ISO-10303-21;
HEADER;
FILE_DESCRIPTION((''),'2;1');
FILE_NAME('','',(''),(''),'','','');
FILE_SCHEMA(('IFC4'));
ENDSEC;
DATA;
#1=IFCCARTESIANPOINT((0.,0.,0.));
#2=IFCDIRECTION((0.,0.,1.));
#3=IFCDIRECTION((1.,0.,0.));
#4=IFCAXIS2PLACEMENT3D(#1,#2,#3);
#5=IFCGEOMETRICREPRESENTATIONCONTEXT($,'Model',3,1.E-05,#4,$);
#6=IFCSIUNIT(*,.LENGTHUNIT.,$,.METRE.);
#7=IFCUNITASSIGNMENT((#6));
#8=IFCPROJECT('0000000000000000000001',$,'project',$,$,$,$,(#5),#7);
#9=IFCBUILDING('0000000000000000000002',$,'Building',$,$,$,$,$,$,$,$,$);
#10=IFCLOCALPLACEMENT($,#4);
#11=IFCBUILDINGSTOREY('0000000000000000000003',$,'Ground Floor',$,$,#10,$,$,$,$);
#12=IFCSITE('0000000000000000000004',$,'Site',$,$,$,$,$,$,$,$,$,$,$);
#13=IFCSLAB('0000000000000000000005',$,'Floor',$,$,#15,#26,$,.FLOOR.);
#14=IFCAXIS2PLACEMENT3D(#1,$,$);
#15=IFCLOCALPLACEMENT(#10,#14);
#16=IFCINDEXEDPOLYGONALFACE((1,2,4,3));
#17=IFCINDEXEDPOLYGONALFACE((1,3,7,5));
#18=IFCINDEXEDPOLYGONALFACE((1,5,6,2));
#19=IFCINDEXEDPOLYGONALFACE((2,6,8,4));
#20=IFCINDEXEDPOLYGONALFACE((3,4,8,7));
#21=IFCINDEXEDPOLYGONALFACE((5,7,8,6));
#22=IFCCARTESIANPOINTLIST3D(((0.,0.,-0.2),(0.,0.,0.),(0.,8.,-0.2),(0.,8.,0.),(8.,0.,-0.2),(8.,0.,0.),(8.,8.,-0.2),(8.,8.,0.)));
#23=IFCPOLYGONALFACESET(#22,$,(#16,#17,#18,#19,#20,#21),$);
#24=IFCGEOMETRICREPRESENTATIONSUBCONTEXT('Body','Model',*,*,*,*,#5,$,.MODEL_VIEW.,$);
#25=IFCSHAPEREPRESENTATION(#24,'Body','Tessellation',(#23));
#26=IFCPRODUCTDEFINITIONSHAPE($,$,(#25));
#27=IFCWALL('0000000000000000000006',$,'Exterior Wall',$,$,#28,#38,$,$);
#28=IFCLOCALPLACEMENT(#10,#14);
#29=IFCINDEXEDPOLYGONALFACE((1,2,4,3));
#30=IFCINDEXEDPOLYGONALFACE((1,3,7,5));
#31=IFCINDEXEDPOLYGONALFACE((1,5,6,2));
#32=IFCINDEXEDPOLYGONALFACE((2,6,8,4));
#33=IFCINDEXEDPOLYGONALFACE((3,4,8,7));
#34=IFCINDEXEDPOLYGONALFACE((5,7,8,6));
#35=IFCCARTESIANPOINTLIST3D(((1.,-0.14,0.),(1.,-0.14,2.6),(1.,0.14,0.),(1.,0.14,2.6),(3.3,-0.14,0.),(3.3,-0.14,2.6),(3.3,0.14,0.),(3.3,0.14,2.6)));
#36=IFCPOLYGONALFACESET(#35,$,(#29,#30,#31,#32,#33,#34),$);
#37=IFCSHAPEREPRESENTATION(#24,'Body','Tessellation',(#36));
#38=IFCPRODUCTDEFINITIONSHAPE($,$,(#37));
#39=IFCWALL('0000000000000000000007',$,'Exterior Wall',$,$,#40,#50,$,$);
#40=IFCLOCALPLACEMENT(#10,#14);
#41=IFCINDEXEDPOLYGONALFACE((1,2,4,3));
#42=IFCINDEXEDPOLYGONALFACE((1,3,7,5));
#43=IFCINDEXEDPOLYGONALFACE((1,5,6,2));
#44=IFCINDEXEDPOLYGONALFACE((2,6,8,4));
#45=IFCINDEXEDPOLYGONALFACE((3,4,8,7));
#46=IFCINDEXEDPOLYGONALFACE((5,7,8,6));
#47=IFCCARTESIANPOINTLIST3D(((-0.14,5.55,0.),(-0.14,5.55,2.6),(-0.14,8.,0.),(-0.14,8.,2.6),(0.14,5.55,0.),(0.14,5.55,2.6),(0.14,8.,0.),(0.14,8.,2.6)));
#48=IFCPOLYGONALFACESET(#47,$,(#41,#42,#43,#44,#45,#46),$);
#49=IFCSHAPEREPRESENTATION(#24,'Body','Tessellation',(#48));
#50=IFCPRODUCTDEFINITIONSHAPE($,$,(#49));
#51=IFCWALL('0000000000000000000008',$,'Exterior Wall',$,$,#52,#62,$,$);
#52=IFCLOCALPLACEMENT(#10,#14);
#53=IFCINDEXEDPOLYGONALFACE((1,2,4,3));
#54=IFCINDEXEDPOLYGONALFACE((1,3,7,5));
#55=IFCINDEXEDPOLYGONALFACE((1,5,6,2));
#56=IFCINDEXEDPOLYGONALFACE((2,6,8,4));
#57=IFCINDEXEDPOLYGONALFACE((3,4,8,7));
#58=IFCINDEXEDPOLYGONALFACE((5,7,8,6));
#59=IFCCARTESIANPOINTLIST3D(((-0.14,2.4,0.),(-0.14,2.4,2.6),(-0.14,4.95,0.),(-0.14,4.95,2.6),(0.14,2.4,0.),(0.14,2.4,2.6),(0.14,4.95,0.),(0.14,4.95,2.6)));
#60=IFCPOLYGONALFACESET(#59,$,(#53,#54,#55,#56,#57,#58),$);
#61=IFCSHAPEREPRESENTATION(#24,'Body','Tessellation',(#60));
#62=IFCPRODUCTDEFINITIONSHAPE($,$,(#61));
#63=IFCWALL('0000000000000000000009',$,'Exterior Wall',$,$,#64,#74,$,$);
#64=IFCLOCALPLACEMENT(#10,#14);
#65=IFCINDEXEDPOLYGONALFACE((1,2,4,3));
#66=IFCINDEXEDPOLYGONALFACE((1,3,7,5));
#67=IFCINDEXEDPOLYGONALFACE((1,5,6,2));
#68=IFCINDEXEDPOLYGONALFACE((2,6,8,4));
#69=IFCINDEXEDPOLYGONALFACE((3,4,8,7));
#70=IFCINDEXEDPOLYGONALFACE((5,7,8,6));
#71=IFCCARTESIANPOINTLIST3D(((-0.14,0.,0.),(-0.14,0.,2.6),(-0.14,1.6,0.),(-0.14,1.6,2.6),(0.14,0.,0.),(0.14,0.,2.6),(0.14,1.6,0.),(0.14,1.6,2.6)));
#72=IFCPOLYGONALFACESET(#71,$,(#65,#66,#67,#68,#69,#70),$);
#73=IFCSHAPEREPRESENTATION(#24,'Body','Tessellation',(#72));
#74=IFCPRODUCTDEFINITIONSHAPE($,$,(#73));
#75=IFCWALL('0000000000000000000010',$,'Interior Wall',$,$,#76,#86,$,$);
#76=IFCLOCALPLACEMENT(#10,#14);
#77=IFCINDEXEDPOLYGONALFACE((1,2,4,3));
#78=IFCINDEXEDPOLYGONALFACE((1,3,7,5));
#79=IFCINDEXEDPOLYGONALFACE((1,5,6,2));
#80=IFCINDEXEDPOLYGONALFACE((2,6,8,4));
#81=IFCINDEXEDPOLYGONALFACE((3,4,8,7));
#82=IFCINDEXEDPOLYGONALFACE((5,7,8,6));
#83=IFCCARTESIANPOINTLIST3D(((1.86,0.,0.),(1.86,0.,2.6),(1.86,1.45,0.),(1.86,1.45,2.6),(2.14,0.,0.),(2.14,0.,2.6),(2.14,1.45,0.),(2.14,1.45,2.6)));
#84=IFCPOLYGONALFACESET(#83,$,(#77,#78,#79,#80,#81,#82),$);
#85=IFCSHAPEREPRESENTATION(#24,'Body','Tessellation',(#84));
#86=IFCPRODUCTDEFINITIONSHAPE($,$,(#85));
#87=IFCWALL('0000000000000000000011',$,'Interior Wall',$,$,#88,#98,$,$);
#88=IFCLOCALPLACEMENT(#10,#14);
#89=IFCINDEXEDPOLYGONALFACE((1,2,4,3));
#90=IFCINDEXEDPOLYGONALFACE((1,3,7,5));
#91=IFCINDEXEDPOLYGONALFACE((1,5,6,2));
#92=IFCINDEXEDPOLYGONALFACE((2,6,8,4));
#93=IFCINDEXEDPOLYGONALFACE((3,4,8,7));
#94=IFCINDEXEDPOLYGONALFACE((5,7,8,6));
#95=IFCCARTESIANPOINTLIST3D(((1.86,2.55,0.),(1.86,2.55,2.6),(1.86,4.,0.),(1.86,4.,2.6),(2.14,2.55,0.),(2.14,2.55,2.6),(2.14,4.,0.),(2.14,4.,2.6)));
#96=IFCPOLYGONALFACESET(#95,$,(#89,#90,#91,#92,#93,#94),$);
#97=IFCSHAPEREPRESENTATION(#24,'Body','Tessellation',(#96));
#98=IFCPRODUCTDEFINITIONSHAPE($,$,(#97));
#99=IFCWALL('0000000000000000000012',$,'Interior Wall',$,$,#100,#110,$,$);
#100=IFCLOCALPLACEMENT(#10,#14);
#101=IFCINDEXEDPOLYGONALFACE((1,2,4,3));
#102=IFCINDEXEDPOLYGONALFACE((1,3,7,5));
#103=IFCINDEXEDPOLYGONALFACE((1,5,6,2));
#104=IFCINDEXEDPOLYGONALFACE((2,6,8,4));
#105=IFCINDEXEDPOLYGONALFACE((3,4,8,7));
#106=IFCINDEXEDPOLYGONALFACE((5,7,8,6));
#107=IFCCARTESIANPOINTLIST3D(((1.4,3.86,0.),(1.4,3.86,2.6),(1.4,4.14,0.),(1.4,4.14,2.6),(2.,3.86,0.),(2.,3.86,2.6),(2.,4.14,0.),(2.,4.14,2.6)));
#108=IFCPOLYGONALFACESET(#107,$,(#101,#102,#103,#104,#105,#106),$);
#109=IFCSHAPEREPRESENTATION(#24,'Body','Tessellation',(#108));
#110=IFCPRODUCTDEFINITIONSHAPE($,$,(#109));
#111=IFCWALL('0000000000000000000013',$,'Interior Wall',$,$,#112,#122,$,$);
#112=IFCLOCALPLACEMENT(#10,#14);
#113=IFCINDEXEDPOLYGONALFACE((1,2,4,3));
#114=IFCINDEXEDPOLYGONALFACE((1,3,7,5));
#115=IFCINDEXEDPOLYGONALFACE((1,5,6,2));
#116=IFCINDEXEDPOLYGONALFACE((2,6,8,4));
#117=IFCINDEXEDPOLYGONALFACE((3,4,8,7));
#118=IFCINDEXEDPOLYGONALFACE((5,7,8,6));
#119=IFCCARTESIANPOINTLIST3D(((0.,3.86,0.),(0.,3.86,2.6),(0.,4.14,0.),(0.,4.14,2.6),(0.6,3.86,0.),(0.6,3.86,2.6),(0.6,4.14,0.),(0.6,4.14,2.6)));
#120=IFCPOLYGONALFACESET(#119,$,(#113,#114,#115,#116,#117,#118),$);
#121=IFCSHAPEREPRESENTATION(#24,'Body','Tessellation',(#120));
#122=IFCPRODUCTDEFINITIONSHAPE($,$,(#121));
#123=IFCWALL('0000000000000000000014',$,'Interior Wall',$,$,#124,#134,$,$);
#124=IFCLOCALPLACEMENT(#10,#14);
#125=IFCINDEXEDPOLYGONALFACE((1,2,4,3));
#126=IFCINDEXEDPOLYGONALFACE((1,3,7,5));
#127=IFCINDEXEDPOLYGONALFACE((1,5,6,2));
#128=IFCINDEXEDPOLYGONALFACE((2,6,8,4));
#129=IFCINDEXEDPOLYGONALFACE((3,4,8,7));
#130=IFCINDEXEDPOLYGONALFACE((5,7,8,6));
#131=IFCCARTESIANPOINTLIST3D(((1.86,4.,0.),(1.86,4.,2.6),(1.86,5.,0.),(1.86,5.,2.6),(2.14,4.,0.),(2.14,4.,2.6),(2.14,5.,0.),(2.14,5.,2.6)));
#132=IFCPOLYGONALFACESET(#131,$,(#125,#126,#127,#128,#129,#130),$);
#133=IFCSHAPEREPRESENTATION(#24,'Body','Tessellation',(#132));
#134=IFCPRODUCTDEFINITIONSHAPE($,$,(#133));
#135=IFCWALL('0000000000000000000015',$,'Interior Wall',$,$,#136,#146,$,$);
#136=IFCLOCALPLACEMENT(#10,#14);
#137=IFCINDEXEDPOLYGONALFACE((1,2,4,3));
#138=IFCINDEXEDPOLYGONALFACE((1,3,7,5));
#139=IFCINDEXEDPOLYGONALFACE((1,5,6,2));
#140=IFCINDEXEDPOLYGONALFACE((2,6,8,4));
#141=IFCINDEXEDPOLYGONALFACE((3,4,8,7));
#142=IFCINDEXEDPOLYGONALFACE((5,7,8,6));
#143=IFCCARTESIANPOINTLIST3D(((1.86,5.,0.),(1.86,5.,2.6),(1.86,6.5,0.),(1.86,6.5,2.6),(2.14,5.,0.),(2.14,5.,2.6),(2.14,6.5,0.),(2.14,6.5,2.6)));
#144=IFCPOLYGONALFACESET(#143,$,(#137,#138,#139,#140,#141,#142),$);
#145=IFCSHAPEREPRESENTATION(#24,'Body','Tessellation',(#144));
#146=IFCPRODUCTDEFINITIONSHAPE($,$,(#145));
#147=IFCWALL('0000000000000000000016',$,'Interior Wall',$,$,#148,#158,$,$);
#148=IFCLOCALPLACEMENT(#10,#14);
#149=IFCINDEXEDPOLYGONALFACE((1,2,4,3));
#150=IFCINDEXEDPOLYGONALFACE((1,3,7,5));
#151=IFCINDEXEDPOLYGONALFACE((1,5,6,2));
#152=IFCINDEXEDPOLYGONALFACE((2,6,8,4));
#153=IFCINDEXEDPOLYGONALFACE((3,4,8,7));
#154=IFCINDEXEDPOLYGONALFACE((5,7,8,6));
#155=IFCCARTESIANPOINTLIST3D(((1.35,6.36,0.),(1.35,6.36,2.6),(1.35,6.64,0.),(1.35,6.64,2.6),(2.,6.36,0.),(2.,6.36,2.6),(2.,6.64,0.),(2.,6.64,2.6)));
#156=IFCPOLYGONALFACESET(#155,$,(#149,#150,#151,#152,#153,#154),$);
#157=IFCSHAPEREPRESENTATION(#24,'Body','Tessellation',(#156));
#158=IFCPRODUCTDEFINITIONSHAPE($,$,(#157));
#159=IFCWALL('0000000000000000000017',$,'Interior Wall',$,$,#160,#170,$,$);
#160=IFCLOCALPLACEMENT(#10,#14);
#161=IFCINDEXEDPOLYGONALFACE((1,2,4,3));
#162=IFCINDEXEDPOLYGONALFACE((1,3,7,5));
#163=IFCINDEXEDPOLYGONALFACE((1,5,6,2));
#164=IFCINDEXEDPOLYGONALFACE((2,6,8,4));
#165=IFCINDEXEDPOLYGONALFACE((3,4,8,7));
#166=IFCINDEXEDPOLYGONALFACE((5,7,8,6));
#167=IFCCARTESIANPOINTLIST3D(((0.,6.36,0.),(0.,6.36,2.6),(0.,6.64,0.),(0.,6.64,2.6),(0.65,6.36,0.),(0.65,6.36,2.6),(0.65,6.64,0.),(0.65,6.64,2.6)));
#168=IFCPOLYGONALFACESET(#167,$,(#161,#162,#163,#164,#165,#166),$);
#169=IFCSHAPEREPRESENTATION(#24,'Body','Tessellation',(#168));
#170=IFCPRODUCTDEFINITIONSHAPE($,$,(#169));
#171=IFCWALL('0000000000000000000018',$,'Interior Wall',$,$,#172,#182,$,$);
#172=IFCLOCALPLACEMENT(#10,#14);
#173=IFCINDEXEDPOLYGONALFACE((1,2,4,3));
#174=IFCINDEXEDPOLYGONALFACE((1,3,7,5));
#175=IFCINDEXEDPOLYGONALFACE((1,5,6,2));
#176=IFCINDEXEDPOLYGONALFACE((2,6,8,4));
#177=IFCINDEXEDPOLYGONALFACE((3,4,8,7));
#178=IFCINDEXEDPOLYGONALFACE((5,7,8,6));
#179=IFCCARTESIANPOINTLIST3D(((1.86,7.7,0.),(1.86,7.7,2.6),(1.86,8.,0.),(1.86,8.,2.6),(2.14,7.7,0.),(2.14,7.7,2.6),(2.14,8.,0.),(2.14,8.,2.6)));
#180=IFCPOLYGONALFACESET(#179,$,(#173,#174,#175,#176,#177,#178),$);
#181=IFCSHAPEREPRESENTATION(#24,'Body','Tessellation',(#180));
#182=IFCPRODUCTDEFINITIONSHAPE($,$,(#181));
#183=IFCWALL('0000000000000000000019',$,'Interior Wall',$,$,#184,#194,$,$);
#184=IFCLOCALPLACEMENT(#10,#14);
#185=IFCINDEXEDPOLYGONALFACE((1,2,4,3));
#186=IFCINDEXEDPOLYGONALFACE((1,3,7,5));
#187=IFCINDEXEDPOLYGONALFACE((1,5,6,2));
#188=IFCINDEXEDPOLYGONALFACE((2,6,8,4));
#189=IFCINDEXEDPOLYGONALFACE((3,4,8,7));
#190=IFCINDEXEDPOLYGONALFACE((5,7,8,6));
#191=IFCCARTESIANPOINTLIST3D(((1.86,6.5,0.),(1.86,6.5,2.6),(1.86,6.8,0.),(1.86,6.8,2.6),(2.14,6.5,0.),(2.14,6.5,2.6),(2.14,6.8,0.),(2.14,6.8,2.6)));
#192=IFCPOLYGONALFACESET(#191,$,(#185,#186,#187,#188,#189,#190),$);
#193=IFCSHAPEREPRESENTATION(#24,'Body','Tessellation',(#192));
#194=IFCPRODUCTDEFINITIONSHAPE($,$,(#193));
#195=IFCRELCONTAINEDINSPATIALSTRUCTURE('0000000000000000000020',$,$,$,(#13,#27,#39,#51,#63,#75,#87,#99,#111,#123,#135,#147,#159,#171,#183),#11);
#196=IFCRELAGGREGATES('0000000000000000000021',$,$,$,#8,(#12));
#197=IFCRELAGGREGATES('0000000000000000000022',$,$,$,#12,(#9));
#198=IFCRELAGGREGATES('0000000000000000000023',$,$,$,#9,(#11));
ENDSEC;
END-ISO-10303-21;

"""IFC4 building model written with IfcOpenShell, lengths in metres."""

from ifc_helpers import new_model, si_unit, frame, origin_with_axes, place, context, subcontext, project, spatial, indexed_curve, outline, extrude, element, save


model = new_model("IFC4")

# Units and contexts
model_context = context("Model", 3, precision=1e-05, world=origin_with_axes())
body_context = subcontext(model_context, "Body", "Model", "MODEL_VIEW")
ifc_project = project(units=[si_unit("LENGTHUNIT", "METRE")], contexts=[model_context])

# Site, building, storey
site = spatial("IfcSite", under=ifc_project, Name="Site")
building = spatial("IfcBuilding", under=site, Name="Building")
storey_placement = place(None, origin_with_axes())
storey = spatial("IfcBuildingStorey", under=building, at=storey_placement, Name="Ground Floor")

# Slab
slab_placement = place(storey_placement, frame((0.0, 0.0, -0.2), z_axis=(0.0, 0.0, 1.0), x_axis=(1.0, 0.0, 0.0)))
element("IfcSlab", 1, at=slab_placement, inside=storey, Name="Floor", PredefinedType="FLOOR", context=body_context, shape_type="SweptSolid", body=[
    extrude(outline(indexed_curve([(0.0, 0.0), (8.0, 0.0), (8.0, 8.0), (0.0, 8.0)])), None, (0.0, 0.0, 1.0), 0.2),
])

# Walls
wall_1_placement = place(storey_placement, frame((1.0, 0.0, 0.0), z_axis=(0.0, 0.0, 1.0), x_axis=(1.0, 0.0, 0.0)))
element("IfcWall", 2, at=wall_1_placement, inside=storey, Name="Exterior Wall", context=body_context, shape_type="SweptSolid", body=[
    extrude(outline(indexed_curve([(0.0, 0.0), (0.0, 0.28), (2.3, 0.28), (2.3, 0.0), (0.0, 0.0)], self_intersect=False)), frame((0.0, -0.14, 0.0), z_axis=(0.0, 0.0, 1.0), x_axis=(1.0, 0.0, 0.0)), (0.0, 0.0, 1.0), 2.6),
])
wall_2_placement = place(storey_placement, frame((0.0, 8.0, 0.0), z_axis=(0.0, 0.0, 1.0), x_axis=(0.0, -1.0, 0.0)))
element("IfcWall", 3, at=wall_2_placement, inside=storey, Name="Exterior Wall", context=body_context, shape_type="SweptSolid", body=[
    extrude(outline(indexed_curve([(0.0, 0.0), (0.0, 0.28), (2.45, 0.28), (2.45, 0.0), (0.0, 0.0)], self_intersect=False)), frame((0.0, -0.14, 0.0), z_axis=(0.0, 0.0, 1.0), x_axis=(1.0, 0.0, 0.0)), (0.0, 0.0, 1.0), 2.6),
])
wall_3_placement = place(storey_placement, frame((0.0, 4.95, 0.0), z_axis=(0.0, 0.0, 1.0), x_axis=(0.0, -1.0, 0.0)))
element("IfcWall", 4, at=wall_3_placement, inside=storey, Name="Exterior Wall", context=body_context, shape_type="SweptSolid", body=[
    extrude(outline(indexed_curve([(0.0, 0.0), (0.0, 0.28), (2.55, 0.28), (2.55, 0.0), (0.0, 0.0)], self_intersect=False)), frame((0.0, -0.14, 0.0), z_axis=(0.0, 0.0, 1.0), x_axis=(1.0, 0.0, 0.0)), (0.0, 0.0, 1.0), 2.6),
])
wall_4_placement = place(storey_placement, frame((0.0, 1.6, 0.0), z_axis=(0.0, 0.0, 1.0), x_axis=(0.0, -1.0, 0.0)))
element("IfcWall", 5, at=wall_4_placement, inside=storey, Name="Exterior Wall", context=body_context, shape_type="SweptSolid", body=[
    extrude(outline(indexed_curve([(0.0, 0.0), (0.0, 0.28), (1.6, 0.28), (1.6, 0.0), (0.0, 0.0)], self_intersect=False)), frame((0.0, -0.14, 0.0), z_axis=(0.0, 0.0, 1.0), x_axis=(1.0, 0.0, 0.0)), (0.0, 0.0, 1.0), 2.6),
])
wall_5_placement = place(storey_placement, frame((2.0, 0.0, 0.0), z_axis=(0.0, 0.0, 1.0), x_axis=(0.0, 1.0, 0.0)))
element("IfcWall", 6, at=wall_5_placement, inside=storey, Name="Interior Wall", context=body_context, shape_type="SweptSolid", body=[
    extrude(outline(indexed_curve([(0.0, 0.0), (0.0, 0.28), (1.45, 0.28), (1.45, 0.0), (0.0, 0.0)], self_intersect=False)), frame((0.0, -0.14, 0.0), z_axis=(0.0, 0.0, 1.0), x_axis=(1.0, 0.0, 0.0)), (0.0, 0.0, 1.0), 2.6),
])
wall_6_placement = place(storey_placement, frame((2.0, 2.55, 0.0), z_axis=(0.0, 0.0, 1.0), x_axis=(0.0, 1.0, 0.0)))
element("IfcWall", 7, at=wall_6_placement, inside=storey, Name="Interior Wall", context=body_context, shape_type="SweptSolid", body=[
    extrude(outline(indexed_curve([(0.0, 0.0), (0.0, 0.28), (1.45, 0.28), (1.45, 0.0), (0.0, 0.0)], self_intersect=False)), frame((0.0, -0.14, 0.0), z_axis=(0.0, 0.0, 1.0), x_axis=(1.0, 0.0, 0.0)), (0.0, 0.0, 1.0), 2.6),
])
for number, where, z_axis, x_axis, name in (
    (8, (2.0, 4.0, 0.0), (0.0, 0.0, 1.0), (-1.0, 0.0, 0.0), "Interior Wall"),
    (9, (0.6, 4.0, 0.0), (0.0, 0.0, 1.0), (-1.0, 0.0, 0.0), "Interior Wall"),
):
    element("IfcWall", number, at=place(storey_placement, frame(where, z_axis=z_axis, x_axis=x_axis)), inside=storey, Name=name, context=body_context, shape_type="SweptSolid", body=[
        extrude(outline(indexed_curve([(0.0, 0.0), (0.0, 0.28), (0.6, 0.28), (0.6, 0.0), (0.0, 0.0)], self_intersect=False)), frame((0.0, -0.14, 0.0), z_axis=(0.0, 0.0, 1.0), x_axis=(1.0, 0.0, 0.0)), (0.0, 0.0, 1.0), 2.6),
    ])
wall_7_placement = place(storey_placement, frame((2.0, 5.0, 0.0), z_axis=(0.0, 0.0, 1.0), x_axis=(0.0, -1.0, 0.0)))
element("IfcWall", 10, at=wall_7_placement, inside=storey, Name="Interior Wall", context=body_context, shape_type="SweptSolid", body=[
    extrude(outline(indexed_curve([(0.0, 0.0), (0.0, 0.28), (1.0, 0.28), (1.0, 0.0), (0.0, 0.0)], self_intersect=False)), frame((0.0, -0.14, 0.0), z_axis=(0.0, 0.0, 1.0), x_axis=(1.0, 0.0, 0.0)), (0.0, 0.0, 1.0), 2.6),
])
wall_8_placement = place(storey_placement, frame((2.0, 5.0, 0.0), z_axis=(0.0, 0.0, 1.0), x_axis=(0.0, 1.0, 0.0)))
element("IfcWall", 11, at=wall_8_placement, inside=storey, Name="Interior Wall", context=body_context, shape_type="SweptSolid", body=[
    extrude(outline(indexed_curve([(0.0, 0.0), (0.0, 0.28), (1.5, 0.28), (1.5, 0.0), (0.0, 0.0)], self_intersect=False)), frame((0.0, -0.14, 0.0), z_axis=(0.0, 0.0, 1.0), x_axis=(1.0, 0.0, 0.0)), (0.0, 0.0, 1.0), 2.6),
])
for number, where, z_axis, x_axis, name in (
    (12, (2.0, 6.5, 0.0), (0.0, 0.0, 1.0), (-1.0, 0.0, 0.0), "Interior Wall"),
    (13, (0.65, 6.5, 0.0), (0.0, 0.0, 1.0), (-1.0, 0.0, 0.0), "Interior Wall"),
):
    element("IfcWall", number, at=place(storey_placement, frame(where, z_axis=z_axis, x_axis=x_axis)), inside=storey, Name=name, context=body_context, shape_type="SweptSolid", body=[
        extrude(outline(indexed_curve([(0.0, 0.0), (0.0, 0.28), (0.65, 0.28), (0.65, 0.0), (0.0, 0.0)], self_intersect=False)), frame((0.0, -0.14, 0.0), z_axis=(0.0, 0.0, 1.0), x_axis=(1.0, 0.0, 0.0)), (0.0, 0.0, 1.0), 2.6),
    ])
for number, where, z_axis, x_axis, name in (
    (14, (2.0, 8.0, 0.0), (0.0, 0.0, 1.0), (0.0, -1.0, 0.0), "Interior Wall"),
    (15, (2.0, 6.8, 0.0), (0.0, 0.0, 1.0), (0.0, -1.0, 0.0), "Interior Wall"),
):
    element("IfcWall", number, at=place(storey_placement, frame(where, z_axis=z_axis, x_axis=x_axis)), inside=storey, Name=name, context=body_context, shape_type="SweptSolid", body=[
        extrude(outline(indexed_curve([(0.0, 0.0), (0.0, 0.28), (0.3, 0.28), (0.3, 0.0), (0.0, 0.0)], self_intersect=False)), frame((0.0, -0.14, 0.0), z_axis=(0.0, 0.0, 1.0), x_axis=(1.0, 0.0, 0.0)), (0.0, 0.0, 1.0), 2.6),
    ])

save(model, "model.ifc")
